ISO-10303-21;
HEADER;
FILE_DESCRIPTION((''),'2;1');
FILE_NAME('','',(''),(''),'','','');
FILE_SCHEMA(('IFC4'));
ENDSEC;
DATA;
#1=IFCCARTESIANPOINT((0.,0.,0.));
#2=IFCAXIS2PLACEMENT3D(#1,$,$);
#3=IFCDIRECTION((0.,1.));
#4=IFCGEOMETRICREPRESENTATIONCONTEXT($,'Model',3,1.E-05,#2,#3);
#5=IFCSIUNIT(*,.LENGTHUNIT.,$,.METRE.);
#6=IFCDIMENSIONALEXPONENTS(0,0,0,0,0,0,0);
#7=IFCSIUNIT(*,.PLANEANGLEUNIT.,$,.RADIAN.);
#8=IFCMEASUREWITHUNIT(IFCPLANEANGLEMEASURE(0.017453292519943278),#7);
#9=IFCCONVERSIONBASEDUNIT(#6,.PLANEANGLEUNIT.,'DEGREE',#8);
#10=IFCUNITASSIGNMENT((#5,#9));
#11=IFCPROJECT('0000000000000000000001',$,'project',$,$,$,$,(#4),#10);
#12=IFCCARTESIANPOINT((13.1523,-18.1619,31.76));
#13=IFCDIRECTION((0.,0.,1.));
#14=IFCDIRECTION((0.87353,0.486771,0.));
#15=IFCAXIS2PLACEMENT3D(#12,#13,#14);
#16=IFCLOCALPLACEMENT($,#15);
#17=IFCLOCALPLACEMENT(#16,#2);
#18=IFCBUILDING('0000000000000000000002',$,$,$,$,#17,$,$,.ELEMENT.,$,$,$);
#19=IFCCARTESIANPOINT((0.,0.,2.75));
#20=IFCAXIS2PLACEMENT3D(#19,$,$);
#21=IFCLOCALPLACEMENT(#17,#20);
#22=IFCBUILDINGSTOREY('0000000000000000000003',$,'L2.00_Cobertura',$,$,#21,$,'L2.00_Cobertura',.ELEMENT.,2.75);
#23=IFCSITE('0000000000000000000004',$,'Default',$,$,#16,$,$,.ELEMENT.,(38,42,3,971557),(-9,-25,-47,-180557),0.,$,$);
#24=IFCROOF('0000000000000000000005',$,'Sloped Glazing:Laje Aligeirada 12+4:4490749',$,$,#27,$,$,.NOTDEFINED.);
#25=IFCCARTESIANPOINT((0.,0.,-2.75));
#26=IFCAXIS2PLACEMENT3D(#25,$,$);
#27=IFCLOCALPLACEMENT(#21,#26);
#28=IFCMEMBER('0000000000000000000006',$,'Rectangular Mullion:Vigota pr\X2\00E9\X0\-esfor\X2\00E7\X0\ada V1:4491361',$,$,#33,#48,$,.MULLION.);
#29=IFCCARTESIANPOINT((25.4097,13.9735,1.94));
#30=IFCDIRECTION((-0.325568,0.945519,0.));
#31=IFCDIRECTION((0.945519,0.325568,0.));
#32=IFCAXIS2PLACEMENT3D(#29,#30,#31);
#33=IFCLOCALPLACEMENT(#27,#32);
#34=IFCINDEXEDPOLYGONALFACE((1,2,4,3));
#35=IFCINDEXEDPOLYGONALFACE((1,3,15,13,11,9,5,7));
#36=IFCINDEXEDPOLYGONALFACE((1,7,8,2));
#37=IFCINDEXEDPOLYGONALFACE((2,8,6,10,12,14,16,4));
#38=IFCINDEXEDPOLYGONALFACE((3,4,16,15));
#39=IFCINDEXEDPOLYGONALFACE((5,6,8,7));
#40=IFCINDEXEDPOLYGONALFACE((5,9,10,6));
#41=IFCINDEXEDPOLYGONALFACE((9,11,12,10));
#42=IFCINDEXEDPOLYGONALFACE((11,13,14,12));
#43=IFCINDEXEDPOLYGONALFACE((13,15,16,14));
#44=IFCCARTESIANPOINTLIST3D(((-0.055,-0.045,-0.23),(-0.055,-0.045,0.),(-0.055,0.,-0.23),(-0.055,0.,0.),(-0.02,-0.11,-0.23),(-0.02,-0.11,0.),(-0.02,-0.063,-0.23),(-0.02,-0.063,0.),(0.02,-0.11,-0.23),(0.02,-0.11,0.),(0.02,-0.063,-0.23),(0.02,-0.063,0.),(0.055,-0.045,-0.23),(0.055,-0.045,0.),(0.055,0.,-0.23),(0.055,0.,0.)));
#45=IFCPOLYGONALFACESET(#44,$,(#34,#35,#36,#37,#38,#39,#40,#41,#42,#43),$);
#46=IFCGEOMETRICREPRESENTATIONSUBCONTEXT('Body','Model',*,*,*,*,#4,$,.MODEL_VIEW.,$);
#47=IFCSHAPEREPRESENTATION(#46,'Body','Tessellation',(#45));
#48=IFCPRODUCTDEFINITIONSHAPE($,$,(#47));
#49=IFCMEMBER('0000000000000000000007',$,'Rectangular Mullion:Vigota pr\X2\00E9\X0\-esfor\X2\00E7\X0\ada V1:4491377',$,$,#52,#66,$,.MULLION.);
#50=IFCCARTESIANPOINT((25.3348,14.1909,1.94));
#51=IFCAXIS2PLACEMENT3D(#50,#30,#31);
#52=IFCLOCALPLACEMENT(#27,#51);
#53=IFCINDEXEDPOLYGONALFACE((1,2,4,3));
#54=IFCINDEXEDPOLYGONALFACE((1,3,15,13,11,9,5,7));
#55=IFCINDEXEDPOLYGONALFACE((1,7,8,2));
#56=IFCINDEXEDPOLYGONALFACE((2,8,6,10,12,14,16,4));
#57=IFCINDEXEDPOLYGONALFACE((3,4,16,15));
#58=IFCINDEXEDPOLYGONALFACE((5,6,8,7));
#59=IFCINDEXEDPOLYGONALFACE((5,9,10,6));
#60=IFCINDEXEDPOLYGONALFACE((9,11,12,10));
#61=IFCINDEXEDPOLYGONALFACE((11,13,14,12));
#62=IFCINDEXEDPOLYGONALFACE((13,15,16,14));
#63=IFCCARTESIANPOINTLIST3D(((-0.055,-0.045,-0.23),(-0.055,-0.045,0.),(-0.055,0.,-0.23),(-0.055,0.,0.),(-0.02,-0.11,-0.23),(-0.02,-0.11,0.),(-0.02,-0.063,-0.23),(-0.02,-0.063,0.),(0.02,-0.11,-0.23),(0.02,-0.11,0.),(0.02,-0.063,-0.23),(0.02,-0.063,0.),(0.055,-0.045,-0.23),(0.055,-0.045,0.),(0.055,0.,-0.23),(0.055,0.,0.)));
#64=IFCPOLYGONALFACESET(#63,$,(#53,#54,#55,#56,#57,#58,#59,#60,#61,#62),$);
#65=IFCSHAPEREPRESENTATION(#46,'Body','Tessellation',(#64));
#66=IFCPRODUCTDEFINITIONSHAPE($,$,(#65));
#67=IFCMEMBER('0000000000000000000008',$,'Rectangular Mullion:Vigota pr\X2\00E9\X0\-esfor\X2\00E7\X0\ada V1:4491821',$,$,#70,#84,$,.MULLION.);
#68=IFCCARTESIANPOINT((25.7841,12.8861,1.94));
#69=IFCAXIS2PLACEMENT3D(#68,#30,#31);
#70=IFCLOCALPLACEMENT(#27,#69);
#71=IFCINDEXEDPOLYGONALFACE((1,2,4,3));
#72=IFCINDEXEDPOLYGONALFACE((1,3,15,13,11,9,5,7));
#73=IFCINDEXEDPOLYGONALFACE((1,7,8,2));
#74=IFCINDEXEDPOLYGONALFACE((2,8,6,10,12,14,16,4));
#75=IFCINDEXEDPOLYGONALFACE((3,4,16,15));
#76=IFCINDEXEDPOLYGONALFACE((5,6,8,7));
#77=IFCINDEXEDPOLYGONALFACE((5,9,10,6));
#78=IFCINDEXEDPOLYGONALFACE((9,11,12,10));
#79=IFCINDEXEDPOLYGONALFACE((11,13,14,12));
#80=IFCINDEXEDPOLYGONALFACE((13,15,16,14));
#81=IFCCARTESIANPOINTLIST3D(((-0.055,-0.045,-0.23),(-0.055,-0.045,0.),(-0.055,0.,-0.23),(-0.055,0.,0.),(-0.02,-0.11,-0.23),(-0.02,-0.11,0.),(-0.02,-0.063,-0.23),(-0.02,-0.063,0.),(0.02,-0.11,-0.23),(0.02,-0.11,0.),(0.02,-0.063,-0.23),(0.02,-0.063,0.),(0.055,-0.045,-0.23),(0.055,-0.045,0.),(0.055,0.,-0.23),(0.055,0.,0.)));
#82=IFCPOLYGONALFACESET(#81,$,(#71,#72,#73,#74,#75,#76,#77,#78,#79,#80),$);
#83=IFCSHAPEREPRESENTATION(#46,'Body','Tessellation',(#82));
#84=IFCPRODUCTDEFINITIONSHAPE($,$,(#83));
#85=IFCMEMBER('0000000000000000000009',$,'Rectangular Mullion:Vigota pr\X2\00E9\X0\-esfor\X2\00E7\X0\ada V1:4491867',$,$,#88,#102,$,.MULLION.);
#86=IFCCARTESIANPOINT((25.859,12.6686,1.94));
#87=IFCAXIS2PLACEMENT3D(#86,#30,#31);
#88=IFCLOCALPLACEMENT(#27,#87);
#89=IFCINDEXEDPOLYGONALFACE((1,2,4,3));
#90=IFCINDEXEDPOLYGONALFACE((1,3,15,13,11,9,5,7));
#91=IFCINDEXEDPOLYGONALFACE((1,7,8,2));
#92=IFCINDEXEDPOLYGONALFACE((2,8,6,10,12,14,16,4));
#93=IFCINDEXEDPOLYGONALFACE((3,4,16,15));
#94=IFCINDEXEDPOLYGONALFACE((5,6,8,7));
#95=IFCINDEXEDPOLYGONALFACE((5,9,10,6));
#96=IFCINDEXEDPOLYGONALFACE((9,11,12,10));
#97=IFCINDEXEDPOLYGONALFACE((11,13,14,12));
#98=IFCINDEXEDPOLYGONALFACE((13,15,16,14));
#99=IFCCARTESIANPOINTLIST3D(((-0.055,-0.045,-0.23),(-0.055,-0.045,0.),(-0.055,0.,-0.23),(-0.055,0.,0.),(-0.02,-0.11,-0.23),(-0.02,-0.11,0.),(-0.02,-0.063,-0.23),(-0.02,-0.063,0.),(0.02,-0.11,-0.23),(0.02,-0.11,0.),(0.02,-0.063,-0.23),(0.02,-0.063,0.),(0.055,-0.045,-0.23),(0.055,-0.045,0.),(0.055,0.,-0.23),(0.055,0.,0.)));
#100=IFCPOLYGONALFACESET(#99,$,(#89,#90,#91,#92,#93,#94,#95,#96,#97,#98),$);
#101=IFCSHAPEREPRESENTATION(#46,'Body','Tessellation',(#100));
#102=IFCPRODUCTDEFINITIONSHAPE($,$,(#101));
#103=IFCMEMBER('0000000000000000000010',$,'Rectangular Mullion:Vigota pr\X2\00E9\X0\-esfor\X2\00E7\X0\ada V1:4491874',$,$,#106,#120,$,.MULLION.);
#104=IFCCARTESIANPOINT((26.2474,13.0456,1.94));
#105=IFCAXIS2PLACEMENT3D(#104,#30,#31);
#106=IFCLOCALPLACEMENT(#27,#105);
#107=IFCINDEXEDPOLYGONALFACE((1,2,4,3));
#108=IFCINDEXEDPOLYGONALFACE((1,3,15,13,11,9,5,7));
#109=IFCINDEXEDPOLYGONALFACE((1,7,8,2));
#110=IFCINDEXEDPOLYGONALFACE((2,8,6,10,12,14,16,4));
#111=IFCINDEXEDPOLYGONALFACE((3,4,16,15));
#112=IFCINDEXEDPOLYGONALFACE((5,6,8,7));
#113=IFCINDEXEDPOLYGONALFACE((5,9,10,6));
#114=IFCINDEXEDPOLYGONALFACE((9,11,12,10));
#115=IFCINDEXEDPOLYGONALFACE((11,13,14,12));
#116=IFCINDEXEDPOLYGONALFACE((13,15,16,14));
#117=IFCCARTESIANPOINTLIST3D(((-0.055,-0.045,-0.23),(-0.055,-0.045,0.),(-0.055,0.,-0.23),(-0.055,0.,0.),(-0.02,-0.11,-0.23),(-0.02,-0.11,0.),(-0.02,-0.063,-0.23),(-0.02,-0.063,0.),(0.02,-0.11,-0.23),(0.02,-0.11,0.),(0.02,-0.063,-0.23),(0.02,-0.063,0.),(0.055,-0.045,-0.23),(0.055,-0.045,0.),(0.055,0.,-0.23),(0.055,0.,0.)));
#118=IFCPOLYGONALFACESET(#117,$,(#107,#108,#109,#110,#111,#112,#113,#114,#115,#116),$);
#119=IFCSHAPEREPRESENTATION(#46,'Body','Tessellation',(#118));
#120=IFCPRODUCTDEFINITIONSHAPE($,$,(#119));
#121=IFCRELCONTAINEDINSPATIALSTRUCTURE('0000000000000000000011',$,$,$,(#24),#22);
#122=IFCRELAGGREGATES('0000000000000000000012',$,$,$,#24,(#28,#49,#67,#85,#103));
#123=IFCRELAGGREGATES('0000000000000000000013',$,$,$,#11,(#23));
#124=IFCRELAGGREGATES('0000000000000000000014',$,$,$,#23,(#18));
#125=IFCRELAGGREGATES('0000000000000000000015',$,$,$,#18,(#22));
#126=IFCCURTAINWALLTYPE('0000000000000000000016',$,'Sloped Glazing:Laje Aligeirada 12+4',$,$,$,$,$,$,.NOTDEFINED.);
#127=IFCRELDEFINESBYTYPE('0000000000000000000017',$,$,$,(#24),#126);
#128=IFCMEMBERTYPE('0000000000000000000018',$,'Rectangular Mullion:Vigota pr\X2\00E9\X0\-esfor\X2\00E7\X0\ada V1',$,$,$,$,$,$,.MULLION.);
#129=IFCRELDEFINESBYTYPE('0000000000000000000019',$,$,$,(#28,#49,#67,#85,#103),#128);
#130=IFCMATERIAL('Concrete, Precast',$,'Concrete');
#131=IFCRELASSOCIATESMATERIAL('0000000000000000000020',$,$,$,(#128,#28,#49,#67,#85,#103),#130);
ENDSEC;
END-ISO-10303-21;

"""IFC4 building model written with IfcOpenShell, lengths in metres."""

from ifc_helpers import new_model, entity, si_unit, converted_unit, direction, frame, origin, place, context, subcontext, project, spatial, indexed_curve, outline, extrude, source, transform, mapped, material, type_object, type_shapes, element, aggregate, save


model = new_model("IFC4")

# Units and contexts
model_context = context("Model", 3, precision=1e-05, world=origin(), true_north=direction((0.0, 1.0)))
body_context = subcontext(model_context, "Body", "Model", "MODEL_VIEW")
ifc_project = project(units=[si_unit("LENGTHUNIT", "METRE"), converted_unit("PLANEANGLEUNIT", "DEGREE", entity("IfcPlaneAngleMeasure", 0.017453292519943278), si_unit("PLANEANGLEUNIT", "RADIAN"), dimensions=[0, 0, 0, 0, 0, 0, 0])], contexts=[model_context])

# Site, building, storey
site_placement = place(None, frame((13.1523, -18.1619, 31.76), z_axis=(0.0, 0.0, 1.0), x_axis=(0.87353, 0.486771, 0.0)))
site = spatial("IfcSite", under=ifc_project, at=site_placement, Name="Default", CompositionType="ELEMENT", RefLatitude=(38, 42, 3, 971557), RefLongitude=(-9, -25, -47, -180557), RefElevation=0.0)
building_placement = place(site_placement, origin())
building = spatial("IfcBuilding", under=site, at=building_placement, CompositionType="ELEMENT")
storey_placement = place(building_placement, frame((0.0, 0.0, 2.75)))
storey = spatial("IfcBuildingStorey", under=building, at=storey_placement, Name="L2.00_Cobertura", LongName="L2.00_Cobertura", CompositionType="ELEMENT", Elevation=2.75)

# Roof, members
curtain_wall_type = type_object("IfcCurtainWallType", Name="Sloped Glazing:Laje Aligeirada 12+4", PredefinedType="NOTDEFINED")
roof_placement = place(storey_placement, frame((0.0, 0.0, -2.75)))
roof = element("IfcRoof", 1, at=roof_placement, inside=storey, type_object=curtain_wall_type, Name="Sloped Glazing:Laje Aligeirada 12+4:4490749", PredefinedType="NOTDEFINED")
ifc_material_1 = material(Name="Concrete, Precast", Category="Concrete")
member_type = type_object("IfcMemberType", Name="Rectangular Mullion:Vigota pré-esforçada V1", PredefinedType="MULLION", material=ifc_material_1)
shared_shape_1 = source(origin(), body_context, "Body", "SweptSolid", [
    extrude(outline(indexed_curve([(-0.055, -0.0545), (0.055, -0.0545), (0.055, -0.0095), (0.02, 0.0085), (0.02, 0.0555), (-0.02, 0.0555), (-0.02, 0.0085), (-0.055, -0.0095), (-0.055, -0.0545)], self_intersect=False)), frame((0.0, -0.0545, -0.23), z_axis=(0.0, 0.0, 1.0), x_axis=(-1.0, 0.0, 0.0)), (0.0, 0.0, 1.0), 0.23),
])
type_shapes(member_type, [shared_shape_1])
member_1_placement = place(roof_placement, frame((25.4097, 13.9735, 1.94), z_axis=(-0.325568, 0.945519, 0.0), x_axis=(0.945519, 0.325568, 0.0)))
member_1 = element("IfcMember", 2, at=member_1_placement, type_object=member_type, material=ifc_material_1, Name="Rectangular Mullion:Vigota pré-esforçada V1:4491361", PredefinedType="MULLION", context=body_context, shape_type="MappedRepresentation", body=[
    mapped(shared_shape_1, transform((0.0, 0.0, 0.0), scale=1.0)),
])
member_2_placement = place(roof_placement, frame((25.3348, 14.1909, 1.94), z_axis=(-0.325568, 0.945519, 0.0), x_axis=(0.945519, 0.325568, 0.0)))
member_2 = element("IfcMember", 3, at=member_2_placement, type_object=member_type, material=ifc_material_1, Name="Rectangular Mullion:Vigota pré-esforçada V1:4491377", PredefinedType="MULLION", context=body_context, shape_type="MappedRepresentation", body=[
    mapped(shared_shape_1, transform((0.0, 0.0, 0.0), scale=1.0)),
])
member_3_placement = place(roof_placement, frame((25.7841, 12.8861, 1.94), z_axis=(-0.325568, 0.945519, 0.0), x_axis=(0.945519, 0.325568, 0.0)))
member_3 = element("IfcMember", 4, at=member_3_placement, type_object=member_type, material=ifc_material_1, Name="Rectangular Mullion:Vigota pré-esforçada V1:4491821", PredefinedType="MULLION", context=body_context, shape_type="MappedRepresentation", body=[
    mapped(shared_shape_1, transform((0.0, 0.0, 0.0), scale=1.0)),
])
member_4_placement = place(roof_placement, frame((25.859, 12.6686, 1.94), z_axis=(-0.325568, 0.945519, 0.0), x_axis=(0.945519, 0.325568, 0.0)))
member_4 = element("IfcMember", 5, at=member_4_placement, type_object=member_type, material=ifc_material_1, Name="Rectangular Mullion:Vigota pré-esforçada V1:4491867", PredefinedType="MULLION", context=body_context, shape_type="MappedRepresentation", body=[
    mapped(shared_shape_1, transform((0.0, 0.0, 0.0), scale=1.0)),
])
member_5_placement = place(roof_placement, frame((26.2474, 13.0456, 1.94), z_axis=(-0.325568, 0.945519, 0.0), x_axis=(0.945519, 0.325568, 0.0)))
member_5 = element("IfcMember", 6, at=member_5_placement, type_object=member_type, material=ifc_material_1, Name="Rectangular Mullion:Vigota pré-esforçada V1:4491874", PredefinedType="MULLION", context=body_context, shape_type="MappedRepresentation", body=[
    mapped(shared_shape_1, transform((0.0, 0.0, 0.0), scale=1.0)),
])
aggregate(roof, [member_1, member_2, member_3, member_4, member_5])

save(model, "model.ifc")
